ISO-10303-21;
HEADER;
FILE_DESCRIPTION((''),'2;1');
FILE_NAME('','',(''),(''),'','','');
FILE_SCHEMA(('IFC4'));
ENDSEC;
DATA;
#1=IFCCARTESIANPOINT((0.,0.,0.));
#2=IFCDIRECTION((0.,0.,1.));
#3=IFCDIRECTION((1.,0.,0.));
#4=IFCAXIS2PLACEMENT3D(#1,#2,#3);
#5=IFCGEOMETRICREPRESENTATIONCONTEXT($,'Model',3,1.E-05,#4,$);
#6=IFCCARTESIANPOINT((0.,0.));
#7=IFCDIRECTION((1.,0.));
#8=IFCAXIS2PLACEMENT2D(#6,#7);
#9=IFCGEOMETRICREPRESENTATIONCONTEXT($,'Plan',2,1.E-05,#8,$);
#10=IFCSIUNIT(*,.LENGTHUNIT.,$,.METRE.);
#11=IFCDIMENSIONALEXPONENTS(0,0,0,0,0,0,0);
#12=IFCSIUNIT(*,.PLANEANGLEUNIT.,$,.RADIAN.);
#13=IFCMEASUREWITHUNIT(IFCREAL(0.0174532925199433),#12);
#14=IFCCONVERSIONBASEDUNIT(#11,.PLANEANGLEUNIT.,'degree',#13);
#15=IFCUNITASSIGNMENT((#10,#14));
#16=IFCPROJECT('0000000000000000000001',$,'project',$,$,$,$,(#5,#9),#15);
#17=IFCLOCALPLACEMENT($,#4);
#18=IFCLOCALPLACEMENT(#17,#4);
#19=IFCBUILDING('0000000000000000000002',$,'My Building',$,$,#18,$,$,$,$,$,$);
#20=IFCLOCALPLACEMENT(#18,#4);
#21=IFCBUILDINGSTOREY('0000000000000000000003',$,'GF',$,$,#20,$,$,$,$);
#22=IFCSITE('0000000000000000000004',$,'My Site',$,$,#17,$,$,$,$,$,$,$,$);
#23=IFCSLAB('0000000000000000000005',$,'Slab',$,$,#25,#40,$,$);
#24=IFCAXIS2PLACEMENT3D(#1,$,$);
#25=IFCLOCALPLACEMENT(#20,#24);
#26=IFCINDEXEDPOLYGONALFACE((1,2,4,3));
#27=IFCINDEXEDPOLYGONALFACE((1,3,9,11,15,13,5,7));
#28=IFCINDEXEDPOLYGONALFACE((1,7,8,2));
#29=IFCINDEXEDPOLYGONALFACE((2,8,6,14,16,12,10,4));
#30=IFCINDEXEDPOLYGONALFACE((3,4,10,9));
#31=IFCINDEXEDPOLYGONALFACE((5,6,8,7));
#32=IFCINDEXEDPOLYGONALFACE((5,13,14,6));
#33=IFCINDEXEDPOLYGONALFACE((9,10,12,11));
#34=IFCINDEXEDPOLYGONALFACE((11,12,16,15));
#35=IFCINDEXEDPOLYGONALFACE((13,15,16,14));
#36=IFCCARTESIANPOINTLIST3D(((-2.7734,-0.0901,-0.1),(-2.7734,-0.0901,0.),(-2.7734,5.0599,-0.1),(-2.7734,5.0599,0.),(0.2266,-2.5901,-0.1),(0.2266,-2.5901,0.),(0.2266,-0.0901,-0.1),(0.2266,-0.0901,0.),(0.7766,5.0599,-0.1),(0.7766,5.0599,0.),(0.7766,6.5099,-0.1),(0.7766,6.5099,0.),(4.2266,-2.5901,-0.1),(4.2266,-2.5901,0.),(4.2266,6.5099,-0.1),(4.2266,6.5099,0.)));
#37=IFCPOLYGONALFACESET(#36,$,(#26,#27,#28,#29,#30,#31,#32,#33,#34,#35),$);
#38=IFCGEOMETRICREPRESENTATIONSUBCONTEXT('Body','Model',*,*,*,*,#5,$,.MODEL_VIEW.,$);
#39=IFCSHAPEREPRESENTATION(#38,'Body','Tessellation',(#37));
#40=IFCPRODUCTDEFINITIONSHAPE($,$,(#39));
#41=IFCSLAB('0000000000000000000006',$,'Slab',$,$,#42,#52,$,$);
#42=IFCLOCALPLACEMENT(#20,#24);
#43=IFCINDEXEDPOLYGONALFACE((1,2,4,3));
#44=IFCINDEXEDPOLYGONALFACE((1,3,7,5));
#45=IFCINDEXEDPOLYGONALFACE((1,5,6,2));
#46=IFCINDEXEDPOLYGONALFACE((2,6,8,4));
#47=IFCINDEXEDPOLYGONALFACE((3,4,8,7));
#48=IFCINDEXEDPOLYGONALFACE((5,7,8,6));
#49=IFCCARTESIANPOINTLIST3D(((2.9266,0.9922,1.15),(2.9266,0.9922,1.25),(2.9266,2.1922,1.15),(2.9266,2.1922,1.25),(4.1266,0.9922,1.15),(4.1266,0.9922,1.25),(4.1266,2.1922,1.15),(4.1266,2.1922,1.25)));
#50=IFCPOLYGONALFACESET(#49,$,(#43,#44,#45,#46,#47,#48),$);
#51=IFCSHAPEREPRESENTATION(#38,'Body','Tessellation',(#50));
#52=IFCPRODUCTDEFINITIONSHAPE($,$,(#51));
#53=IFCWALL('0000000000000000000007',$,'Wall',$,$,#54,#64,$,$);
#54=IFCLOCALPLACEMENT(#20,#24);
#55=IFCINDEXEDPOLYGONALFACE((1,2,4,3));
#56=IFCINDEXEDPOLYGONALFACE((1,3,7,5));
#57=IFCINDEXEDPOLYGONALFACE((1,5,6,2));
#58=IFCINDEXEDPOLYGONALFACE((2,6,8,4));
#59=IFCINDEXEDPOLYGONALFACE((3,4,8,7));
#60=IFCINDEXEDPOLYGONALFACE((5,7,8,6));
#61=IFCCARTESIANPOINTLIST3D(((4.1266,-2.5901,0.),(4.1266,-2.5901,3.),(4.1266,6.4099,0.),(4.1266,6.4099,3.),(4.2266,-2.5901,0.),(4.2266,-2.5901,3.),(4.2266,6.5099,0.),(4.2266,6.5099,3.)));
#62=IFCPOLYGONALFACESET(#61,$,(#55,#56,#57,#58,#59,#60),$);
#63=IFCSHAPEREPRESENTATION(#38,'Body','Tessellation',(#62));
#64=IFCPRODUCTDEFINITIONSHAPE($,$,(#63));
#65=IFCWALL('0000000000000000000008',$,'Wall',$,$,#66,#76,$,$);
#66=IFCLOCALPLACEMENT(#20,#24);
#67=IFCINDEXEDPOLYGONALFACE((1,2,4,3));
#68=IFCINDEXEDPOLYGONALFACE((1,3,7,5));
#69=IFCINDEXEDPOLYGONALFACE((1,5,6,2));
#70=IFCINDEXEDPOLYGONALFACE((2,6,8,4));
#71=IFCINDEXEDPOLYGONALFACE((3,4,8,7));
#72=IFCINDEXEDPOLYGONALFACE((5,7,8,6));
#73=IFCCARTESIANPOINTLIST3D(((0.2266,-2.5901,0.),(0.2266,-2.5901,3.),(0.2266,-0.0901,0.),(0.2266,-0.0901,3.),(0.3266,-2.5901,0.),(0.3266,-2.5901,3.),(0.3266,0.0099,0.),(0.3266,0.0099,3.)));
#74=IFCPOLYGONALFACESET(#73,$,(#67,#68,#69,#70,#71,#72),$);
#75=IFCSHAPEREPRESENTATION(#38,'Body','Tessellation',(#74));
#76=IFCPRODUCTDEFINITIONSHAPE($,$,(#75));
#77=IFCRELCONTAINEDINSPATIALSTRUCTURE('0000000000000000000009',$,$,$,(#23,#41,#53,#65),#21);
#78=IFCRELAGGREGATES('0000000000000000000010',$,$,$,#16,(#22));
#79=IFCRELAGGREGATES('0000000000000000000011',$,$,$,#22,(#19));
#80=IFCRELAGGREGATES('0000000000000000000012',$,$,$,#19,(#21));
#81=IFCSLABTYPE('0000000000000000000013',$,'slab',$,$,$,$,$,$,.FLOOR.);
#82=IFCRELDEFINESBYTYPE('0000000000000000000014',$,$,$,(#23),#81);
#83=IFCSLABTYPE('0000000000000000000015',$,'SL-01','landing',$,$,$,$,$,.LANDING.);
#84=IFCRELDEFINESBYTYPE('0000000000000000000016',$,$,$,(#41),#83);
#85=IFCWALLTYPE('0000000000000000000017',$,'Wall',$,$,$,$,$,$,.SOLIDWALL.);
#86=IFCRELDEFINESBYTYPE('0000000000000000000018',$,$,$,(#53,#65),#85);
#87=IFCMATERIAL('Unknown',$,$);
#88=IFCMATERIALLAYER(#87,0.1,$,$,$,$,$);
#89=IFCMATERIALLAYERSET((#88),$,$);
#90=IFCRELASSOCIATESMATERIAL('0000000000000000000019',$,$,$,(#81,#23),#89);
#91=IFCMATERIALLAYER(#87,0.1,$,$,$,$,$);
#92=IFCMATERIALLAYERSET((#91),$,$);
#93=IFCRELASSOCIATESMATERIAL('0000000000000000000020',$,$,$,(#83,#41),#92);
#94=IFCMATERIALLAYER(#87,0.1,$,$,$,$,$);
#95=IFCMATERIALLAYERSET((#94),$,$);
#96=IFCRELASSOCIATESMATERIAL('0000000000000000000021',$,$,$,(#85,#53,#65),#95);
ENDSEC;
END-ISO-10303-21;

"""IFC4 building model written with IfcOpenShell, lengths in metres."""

from ifc_helpers import new_model, entity, si_unit, converted_unit, frame, origin_with_axes, origin_2d_with_axis, place, context, subcontext, project, spatial, line, indexed_curve, outline, extrude, material, layer, layer_set, layer_usage, type_object, element, save


model = new_model("IFC4")

# Units and contexts
model_context = context("Model", 3, precision=1e-05, world=origin_with_axes())
plan_context = context("Plan", 2, precision=1e-05, world=origin_2d_with_axis())
body_context_1 = subcontext(model_context, "Body", "Model", "MODEL_VIEW")
ifc_project = project(units=[si_unit("LENGTHUNIT", "METRE"), converted_unit("PLANEANGLEUNIT", "degree", entity("IfcReal", 0.0174532925199433), si_unit("PLANEANGLEUNIT", "RADIAN"), dimensions=[0, 0, 0, 0, 0, 0, 0])], contexts=[model_context, plan_context])

# Site, building, storey
site_placement = place(None, origin_with_axes())
site = spatial("IfcSite", under=ifc_project, at=site_placement, Name="My Site")
building_placement = place(site_placement, origin_with_axes())
building = spatial("IfcBuilding", under=site, at=building_placement, Name="My Building")
storey_placement = place(building_placement, origin_with_axes())
storey = spatial("IfcBuildingStorey", under=building, at=storey_placement, Name="GF")

# Shared definitions
ifc_material = material(Name="Unknown")

# Slabs
ifc_layer_1 = layer(ifc_material, 0.1)
ifc_layer_set_1 = layer_set([ifc_layer_1])
ifc_layer_usage_1 = layer_usage(ifc_layer_set_1, "AXIS3", "POSITIVE", -0.1)
slab_type_1 = type_object("IfcSlabType", Name="slab", PredefinedType="FLOOR", material=ifc_layer_set_1)
slab_1_placement = place(storey_placement, frame((4.2266, -2.5901, 0.0), z_axis=(0.0, 0.0, 1.0), x_axis=(1.0, 0.0, 0.0)))
element("IfcSlab", 1, at=slab_1_placement, inside=storey, type_object=slab_type_1, material=ifc_layer_usage_1, Name="Slab", context=body_context_1, shape_type="SweptSolid", body=[
    extrude(outline(indexed_curve([(0.0, 0.0), (0.0, 9.1), (-3.45, 9.1), (-3.45, 7.65), (-7.0, 7.65), (-7.0, 2.5), (-4.0, 2.5), (-4.0, 0.0), (0.0, 0.0)])), frame((0.0, 0.0, -0.1), z_axis=(0.0, 0.0, 1.0), x_axis=(1.0, 0.0, 0.0)), (0.0, 0.0, 1.0), 0.1),
])
ifc_layer_2 = layer(ifc_material, 0.1)
ifc_layer_set_2 = layer_set([ifc_layer_2])
ifc_layer_usage_2 = layer_usage(ifc_layer_set_2, "AXIS3", "POSITIVE", -0.1)
slab_type_2 = type_object("IfcSlabType", Name="SL-01", Description="landing", PredefinedType="LANDING", material=ifc_layer_set_2)
slab_2_placement = place(storey_placement, frame((2.9266, 2.1922, 1.25), z_axis=(0.0, 0.0, 1.0), x_axis=(1.0, 0.0, 0.0)))
element("IfcSlab", 2, at=slab_2_placement, inside=storey, type_object=slab_type_2, material=ifc_layer_usage_2, Name="Slab", context=body_context_1, shape_type="SweptSolid", body=[
    extrude(outline(indexed_curve([(0.0, 0.0), (0.0, -1.2), (1.2, -1.2), (1.2, 0.0), (0.0, 0.0)])), frame((0.0, 0.0, -0.1), z_axis=(0.0, 0.0, 1.0), x_axis=(1.0, 0.0, 0.0)), (0.0, 0.0, 1.0), 0.1),
])

# Shared definitions
ifc_layer_3 = layer(ifc_material, 0.1)
ifc_layer_set_3 = layer_set([ifc_layer_3])
wall_type = type_object("IfcWallType", Name="Wall", PredefinedType="SOLIDWALL", material=ifc_layer_set_3)

# Walls
ifc_layer_usage_3 = layer_usage(ifc_layer_set_3, "AXIS2", "POSITIVE", 0.0)
wall_1_placement = place(storey_placement, frame((4.2266, -2.5901, 0.0), z_axis=(0.0, 0.0, 1.0), x_axis=(0.0, 1.0, 0.0)))
element("IfcWall", 3, at=wall_1_placement, inside=storey, type_object=wall_type, material=ifc_layer_usage_3, Name="Wall", context=body_context_1, shape_type="SweptSolid", body=[
    extrude(outline(indexed_curve([(0.0, 0.0), (0.0, 0.1), (9.0, 0.1), (9.1, 0.0)], segments=[line(1, 2, 3, 4, 1)])), origin_with_axes(), (0.0, 0.0, 1.0), 3.0),
])
ifc_layer_usage_4 = layer_usage(ifc_layer_set_3, "AXIS2", "POSITIVE", 0.0)
wall_2_placement = place(storey_placement, frame((0.2266, -0.0901, 0.0), z_axis=(0.0, 0.0, 1.0), x_axis=(0.0, -1.0, 0.0)))
element("IfcWall", 4, at=wall_2_placement, inside=storey, type_object=wall_type, material=ifc_layer_usage_4, Name="Wall", context=body_context_1, shape_type="SweptSolid", body=[
    extrude(outline(indexed_curve([(0.0, 0.0), (-0.1, 0.1), (2.5, 0.1), (2.5, 0.0)], segments=[line(1, 2, 3, 4, 1)])), origin_with_axes(), (0.0, 0.0, 1.0), 3.0),
])

save(model, "model.ifc")
